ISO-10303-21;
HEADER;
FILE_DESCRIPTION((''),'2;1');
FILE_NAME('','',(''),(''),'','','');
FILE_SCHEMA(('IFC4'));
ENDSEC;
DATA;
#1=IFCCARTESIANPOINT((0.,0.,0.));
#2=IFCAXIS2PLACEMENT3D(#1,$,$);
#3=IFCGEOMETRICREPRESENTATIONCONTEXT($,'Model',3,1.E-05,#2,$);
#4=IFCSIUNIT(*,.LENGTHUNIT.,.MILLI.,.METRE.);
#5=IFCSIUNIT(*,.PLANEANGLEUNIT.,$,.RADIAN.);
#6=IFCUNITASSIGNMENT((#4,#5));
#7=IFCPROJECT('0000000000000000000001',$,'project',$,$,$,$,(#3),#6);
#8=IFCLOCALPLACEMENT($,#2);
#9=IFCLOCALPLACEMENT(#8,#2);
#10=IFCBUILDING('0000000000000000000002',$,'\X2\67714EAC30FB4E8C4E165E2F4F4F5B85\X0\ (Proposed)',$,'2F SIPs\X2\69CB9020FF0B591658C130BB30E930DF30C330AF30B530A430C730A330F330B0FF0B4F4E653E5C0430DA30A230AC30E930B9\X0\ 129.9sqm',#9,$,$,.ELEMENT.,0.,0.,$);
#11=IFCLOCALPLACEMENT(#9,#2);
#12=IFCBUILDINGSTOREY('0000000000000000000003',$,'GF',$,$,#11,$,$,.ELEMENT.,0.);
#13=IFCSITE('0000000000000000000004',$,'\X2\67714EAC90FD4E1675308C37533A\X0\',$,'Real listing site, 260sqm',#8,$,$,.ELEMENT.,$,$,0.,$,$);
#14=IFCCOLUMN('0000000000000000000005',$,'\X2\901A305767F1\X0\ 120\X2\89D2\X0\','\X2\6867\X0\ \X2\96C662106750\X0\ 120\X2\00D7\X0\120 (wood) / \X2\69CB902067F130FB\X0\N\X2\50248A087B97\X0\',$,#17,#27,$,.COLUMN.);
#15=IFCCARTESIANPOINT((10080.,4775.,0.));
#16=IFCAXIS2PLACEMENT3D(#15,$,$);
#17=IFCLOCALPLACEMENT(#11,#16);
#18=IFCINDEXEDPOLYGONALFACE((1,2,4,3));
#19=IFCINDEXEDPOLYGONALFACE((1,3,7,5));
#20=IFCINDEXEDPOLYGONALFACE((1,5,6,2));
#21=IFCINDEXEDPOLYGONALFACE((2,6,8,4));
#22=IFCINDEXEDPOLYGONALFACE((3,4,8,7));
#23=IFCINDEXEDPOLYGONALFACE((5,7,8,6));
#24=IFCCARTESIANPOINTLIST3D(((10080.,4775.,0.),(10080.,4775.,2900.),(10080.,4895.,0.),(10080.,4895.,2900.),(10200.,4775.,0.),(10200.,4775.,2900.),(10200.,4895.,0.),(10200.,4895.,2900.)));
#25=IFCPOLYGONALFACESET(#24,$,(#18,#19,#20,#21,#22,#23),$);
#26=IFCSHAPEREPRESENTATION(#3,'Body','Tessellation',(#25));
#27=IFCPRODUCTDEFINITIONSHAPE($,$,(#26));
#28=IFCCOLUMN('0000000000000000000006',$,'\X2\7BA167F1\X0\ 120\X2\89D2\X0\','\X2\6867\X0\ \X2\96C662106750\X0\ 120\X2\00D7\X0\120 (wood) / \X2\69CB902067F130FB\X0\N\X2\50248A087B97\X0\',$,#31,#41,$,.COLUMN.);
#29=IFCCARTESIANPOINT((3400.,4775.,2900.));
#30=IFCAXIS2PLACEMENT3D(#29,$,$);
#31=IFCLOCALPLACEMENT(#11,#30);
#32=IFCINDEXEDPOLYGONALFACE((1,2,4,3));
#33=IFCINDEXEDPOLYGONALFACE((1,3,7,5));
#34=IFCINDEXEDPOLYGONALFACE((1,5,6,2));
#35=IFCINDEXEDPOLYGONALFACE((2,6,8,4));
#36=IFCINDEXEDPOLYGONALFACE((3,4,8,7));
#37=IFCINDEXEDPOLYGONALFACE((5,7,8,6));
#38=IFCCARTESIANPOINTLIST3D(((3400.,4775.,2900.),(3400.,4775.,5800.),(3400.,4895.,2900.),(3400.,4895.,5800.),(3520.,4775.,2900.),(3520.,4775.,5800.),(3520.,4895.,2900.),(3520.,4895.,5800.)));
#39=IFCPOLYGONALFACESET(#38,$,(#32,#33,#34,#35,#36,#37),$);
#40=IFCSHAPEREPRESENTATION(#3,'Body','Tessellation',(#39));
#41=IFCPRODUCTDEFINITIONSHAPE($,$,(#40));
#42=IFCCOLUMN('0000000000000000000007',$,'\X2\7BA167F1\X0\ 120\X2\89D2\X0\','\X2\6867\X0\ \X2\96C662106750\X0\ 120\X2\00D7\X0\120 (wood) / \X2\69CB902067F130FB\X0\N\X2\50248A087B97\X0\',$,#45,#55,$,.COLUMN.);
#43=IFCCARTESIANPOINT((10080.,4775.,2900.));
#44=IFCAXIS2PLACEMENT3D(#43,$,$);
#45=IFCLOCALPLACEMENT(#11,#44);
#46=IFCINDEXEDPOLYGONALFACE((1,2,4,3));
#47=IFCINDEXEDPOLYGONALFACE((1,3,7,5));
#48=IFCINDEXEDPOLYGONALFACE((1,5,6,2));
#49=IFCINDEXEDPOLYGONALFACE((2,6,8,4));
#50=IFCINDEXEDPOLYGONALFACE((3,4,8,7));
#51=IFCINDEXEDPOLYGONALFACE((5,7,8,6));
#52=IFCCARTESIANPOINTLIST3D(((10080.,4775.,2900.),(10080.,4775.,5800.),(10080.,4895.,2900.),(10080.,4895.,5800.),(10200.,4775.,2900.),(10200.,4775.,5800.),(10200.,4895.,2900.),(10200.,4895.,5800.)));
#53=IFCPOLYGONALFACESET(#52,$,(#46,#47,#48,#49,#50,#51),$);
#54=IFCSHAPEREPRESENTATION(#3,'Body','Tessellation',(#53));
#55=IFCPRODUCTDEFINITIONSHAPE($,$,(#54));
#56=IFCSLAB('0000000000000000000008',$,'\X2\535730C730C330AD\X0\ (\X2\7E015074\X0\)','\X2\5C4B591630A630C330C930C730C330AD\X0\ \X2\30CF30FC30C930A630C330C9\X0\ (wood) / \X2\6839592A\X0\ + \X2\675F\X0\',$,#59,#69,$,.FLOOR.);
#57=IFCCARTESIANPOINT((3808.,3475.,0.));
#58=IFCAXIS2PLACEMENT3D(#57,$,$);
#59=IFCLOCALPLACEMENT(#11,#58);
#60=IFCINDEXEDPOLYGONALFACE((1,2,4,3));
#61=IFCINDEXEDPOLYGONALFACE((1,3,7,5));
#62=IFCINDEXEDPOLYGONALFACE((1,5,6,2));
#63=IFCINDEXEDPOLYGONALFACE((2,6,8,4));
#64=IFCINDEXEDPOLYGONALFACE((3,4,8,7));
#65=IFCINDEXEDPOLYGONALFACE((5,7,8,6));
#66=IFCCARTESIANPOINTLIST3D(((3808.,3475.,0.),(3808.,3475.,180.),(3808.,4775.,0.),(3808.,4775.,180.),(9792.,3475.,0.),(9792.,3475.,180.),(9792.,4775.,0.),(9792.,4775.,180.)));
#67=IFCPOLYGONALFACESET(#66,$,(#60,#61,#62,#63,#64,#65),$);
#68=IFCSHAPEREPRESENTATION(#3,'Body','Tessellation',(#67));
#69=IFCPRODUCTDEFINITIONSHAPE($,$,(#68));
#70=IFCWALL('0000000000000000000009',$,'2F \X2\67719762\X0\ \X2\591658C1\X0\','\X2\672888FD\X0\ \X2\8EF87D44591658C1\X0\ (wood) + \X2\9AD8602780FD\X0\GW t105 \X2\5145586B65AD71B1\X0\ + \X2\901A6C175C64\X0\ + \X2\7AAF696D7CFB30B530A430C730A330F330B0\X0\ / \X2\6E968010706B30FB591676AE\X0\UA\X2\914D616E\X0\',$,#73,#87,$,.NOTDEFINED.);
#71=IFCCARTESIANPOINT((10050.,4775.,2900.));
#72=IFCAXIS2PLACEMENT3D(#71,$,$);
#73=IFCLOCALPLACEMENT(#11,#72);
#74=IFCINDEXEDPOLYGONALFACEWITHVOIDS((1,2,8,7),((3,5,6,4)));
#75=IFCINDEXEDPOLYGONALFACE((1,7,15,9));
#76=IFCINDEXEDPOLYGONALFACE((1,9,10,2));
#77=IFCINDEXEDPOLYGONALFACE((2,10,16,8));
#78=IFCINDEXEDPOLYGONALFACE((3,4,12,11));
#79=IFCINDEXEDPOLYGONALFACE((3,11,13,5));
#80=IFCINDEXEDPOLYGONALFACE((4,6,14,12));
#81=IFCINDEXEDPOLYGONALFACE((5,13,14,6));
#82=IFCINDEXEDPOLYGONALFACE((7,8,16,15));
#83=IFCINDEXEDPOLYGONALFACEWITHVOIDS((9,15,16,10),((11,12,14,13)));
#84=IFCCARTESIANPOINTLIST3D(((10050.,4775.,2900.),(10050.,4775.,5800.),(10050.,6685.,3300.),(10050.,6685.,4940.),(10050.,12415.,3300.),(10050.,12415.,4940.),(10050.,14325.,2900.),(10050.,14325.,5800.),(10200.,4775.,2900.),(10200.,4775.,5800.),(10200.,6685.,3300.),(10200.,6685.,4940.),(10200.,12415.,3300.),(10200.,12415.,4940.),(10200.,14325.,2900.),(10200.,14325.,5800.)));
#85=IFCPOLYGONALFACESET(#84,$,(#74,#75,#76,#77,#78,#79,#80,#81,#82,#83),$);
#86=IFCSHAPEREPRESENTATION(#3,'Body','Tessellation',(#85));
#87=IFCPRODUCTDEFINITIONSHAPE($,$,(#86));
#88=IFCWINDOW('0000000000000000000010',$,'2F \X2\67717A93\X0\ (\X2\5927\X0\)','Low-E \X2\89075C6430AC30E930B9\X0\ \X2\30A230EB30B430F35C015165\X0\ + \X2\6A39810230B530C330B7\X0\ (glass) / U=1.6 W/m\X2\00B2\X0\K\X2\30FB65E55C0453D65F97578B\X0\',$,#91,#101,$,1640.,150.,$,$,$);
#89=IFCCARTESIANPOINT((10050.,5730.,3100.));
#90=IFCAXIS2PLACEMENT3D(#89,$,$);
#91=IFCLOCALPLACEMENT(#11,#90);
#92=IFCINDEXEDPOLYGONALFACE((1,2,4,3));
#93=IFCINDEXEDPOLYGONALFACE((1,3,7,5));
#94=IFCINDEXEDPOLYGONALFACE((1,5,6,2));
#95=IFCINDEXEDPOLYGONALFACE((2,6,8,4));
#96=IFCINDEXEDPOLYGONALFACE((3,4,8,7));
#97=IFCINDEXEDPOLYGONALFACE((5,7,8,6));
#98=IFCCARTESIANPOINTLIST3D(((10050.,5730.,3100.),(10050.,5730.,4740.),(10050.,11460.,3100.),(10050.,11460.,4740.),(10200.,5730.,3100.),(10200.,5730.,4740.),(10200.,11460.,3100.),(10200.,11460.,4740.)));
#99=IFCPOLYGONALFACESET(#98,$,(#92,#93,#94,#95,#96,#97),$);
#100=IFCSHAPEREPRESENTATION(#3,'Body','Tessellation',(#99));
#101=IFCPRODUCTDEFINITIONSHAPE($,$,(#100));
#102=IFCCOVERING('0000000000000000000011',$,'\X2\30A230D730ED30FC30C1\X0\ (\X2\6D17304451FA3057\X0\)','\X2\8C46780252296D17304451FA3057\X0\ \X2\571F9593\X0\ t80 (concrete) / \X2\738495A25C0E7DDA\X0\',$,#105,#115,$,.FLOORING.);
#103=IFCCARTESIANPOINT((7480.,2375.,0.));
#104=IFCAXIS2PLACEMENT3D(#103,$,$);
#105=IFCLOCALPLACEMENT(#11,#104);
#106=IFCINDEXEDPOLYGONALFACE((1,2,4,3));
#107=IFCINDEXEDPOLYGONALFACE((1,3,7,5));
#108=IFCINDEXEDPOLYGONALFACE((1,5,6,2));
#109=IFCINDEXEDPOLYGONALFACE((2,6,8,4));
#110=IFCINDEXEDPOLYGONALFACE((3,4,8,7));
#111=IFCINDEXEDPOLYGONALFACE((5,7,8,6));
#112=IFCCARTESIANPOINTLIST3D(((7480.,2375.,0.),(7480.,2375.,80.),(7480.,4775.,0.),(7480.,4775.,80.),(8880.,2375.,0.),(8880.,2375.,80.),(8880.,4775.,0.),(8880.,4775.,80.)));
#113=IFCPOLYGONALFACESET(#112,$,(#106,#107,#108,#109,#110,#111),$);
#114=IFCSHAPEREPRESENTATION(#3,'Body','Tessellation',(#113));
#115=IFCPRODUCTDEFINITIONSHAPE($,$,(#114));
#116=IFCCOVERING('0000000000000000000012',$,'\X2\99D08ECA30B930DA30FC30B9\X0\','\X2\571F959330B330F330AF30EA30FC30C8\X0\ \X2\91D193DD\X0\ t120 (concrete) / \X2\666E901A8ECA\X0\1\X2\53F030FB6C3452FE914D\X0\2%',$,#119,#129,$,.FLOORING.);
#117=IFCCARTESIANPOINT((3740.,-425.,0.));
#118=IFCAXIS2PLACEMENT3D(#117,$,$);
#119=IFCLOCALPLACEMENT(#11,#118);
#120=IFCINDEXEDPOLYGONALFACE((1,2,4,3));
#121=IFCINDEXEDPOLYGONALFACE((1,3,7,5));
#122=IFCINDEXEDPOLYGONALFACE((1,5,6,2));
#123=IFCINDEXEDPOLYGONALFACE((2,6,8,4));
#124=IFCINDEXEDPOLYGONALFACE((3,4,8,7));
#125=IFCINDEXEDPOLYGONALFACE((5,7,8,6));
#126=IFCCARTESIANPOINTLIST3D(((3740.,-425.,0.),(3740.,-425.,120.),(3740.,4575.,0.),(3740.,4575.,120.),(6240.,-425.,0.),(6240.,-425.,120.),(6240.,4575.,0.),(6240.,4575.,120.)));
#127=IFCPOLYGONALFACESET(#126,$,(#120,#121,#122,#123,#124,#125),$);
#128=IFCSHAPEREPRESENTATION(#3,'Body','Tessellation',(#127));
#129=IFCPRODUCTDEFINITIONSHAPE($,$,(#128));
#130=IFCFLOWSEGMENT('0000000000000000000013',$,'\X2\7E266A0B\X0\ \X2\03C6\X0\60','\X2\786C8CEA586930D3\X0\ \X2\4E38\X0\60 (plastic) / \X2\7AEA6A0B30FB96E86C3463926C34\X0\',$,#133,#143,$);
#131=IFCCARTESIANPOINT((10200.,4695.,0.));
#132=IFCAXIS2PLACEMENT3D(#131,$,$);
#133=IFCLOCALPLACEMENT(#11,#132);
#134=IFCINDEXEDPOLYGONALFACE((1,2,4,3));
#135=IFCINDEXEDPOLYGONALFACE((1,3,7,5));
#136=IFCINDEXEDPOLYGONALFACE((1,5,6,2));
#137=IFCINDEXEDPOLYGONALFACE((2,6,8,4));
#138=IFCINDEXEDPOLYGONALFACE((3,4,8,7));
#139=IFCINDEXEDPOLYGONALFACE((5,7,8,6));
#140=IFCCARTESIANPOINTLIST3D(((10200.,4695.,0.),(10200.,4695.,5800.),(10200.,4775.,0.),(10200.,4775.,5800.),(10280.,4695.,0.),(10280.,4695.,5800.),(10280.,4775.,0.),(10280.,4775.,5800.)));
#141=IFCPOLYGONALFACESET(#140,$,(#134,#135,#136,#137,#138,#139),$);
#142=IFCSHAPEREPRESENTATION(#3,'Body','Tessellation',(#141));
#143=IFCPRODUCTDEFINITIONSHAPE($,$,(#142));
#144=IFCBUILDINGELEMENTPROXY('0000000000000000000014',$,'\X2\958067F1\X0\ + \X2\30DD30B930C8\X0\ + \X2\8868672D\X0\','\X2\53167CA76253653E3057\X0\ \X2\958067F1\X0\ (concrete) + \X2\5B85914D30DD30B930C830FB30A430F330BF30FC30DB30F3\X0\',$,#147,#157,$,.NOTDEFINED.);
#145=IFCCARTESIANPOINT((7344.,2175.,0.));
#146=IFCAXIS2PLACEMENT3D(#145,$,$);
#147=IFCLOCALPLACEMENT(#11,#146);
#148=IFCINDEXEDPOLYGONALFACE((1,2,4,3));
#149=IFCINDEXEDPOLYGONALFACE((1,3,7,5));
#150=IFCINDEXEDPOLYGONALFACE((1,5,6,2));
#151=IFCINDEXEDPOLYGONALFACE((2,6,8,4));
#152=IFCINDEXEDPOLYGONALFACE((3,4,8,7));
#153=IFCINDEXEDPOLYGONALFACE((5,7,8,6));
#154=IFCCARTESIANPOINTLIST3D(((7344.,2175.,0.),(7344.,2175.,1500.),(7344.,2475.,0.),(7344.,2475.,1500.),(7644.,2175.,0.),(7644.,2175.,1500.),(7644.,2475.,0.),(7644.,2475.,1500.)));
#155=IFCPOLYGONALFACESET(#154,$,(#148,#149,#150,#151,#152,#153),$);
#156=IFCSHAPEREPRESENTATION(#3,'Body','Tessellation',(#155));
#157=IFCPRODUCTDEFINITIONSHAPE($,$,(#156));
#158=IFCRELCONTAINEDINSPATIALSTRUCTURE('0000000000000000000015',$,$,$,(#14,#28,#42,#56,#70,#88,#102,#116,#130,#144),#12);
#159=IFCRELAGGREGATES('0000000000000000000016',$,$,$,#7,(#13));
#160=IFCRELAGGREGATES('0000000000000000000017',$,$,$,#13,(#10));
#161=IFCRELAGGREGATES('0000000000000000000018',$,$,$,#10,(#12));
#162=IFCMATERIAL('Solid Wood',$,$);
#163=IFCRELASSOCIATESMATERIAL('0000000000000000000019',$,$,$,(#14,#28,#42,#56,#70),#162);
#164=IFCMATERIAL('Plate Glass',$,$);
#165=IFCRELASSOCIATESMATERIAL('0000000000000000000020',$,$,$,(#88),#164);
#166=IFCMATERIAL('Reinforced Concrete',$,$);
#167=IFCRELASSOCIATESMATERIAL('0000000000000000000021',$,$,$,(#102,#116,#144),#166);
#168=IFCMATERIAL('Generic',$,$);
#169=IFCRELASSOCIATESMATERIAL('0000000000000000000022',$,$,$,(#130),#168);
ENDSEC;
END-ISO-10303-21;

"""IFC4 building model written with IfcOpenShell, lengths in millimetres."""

from ifc_helpers import new_model, si_unit, frame, frame_2d, origin, place, context, project, spatial, rectangle, extrude, material, element, fill, save


model = new_model("IFC4")

# Units and contexts
model_context = context("Model", 3, precision=1e-05, world=origin())
ifc_project = project(units=[si_unit("LENGTHUNIT", "METRE", prefix="MILLI"), si_unit("PLANEANGLEUNIT", "RADIAN")], contexts=[model_context])

# Site, building, storey
site_placement = place(None, origin())
site = spatial("IfcSite", under=ifc_project, at=site_placement, Name="東京都世田谷区", ObjectType="Real listing site, 260sqm", CompositionType="ELEMENT", RefElevation=0.0)
building_placement = place(site_placement, origin())
building = spatial("IfcBuilding", under=site, at=building_placement, Name="東京・二世帯住宅 (Proposed)", ObjectType="2F SIPs構造＋外壁セラミックサイディング＋低放射ペアガラス 129.9sqm", CompositionType="ELEMENT", ElevationOfRefHeight=0.0, ElevationOfTerrain=0.0)
storey_placement = place(building_placement, origin())
storey = spatial("IfcBuildingStorey", under=building, at=storey_placement, Name="GF", CompositionType="ELEMENT", Elevation=0.0)

# Columns
ifc_material_1 = material(Name="Solid Wood")
column_1_placement = place(storey_placement, frame((10080.0, 4775.0, 0.0)))
element("IfcColumn", 1, at=column_1_placement, inside=storey, material=ifc_material_1, Name="通し柱 120角", Description="桧 集成材 120×120 (wood) / 構造柱・N値計算", PredefinedType="COLUMN", context=model_context, shape_type="SweptSolid", body=[
    extrude(rectangle(XDim=120.0, YDim=120.0, at=frame_2d((60.0, 60.0))), frame((10080.0, 4775.0, 0.0)), (0.0, 0.0, 1.0), 2900.0),
])
column_2_placement = place(storey_placement, frame((3400.0, 4775.0, 2900.0)))
element("IfcColumn", 2, at=column_2_placement, inside=storey, material=ifc_material_1, Name="管柱 120角", Description="桧 集成材 120×120 (wood) / 構造柱・N値計算", PredefinedType="COLUMN", context=model_context, shape_type="SweptSolid", body=[
    extrude(rectangle(XDim=120.0, YDim=120.0, at=frame_2d((60.0, 60.0))), frame((3400.0, 4775.0, 2900.0)), (0.0, 0.0, 1.0), 2900.0),
])
column_3_placement = place(storey_placement, frame((10080.0, 4775.0, 2900.0)))
element("IfcColumn", 3, at=column_3_placement, inside=storey, material=ifc_material_1, Name="管柱 120角", Description="桧 集成材 120×120 (wood) / 構造柱・N値計算", PredefinedType="COLUMN", context=model_context, shape_type="SweptSolid", body=[
    extrude(rectangle(XDim=120.0, YDim=120.0, at=frame_2d((60.0, 60.0))), frame((10080.0, 4775.0, 2900.0)), (0.0, 0.0, 1.0), 2900.0),
])

# Slab
slab_placement = place(storey_placement, frame((3808.0, 3475.0, 0.0)))
element("IfcSlab", 4, at=slab_placement, inside=storey, material=ifc_material_1, Name="南デッキ (縁側)", Description="屋外ウッドデッキ ハードウッド (wood) / 根太 + 束", PredefinedType="FLOOR", context=model_context, shape_type="SweptSolid", body=[
    extrude(rectangle(XDim=5984.0, YDim=1300.0, at=frame_2d((2992.0, 650.0))), frame((3808.0, 3475.0, 0.0)), (0.0, 0.0, 1.0), 180.0),
])

# Wall, opening, window
ifc_material_2 = material(Name="Plate Glass")
wall_1_placement = place(storey_placement, frame((10050.0, 4775.0, 2900.0)))
wall_1 = element("IfcWall", 5, at=wall_1_placement, inside=storey, material=ifc_material_1, Name="2F 東面 外壁", Description="木製 軸組外壁 (wood) + 高性能GW t105 充填断熱 + 通気層 + 窯業系サイディング / 準耐火・外皮UA配慮", PredefinedType="NOTDEFINED", context=model_context, shape_type="SweptSolid", body=[
    extrude(rectangle(XDim=150.0, YDim=9550.0, at=frame_2d((75.0, 4775.0))), frame((10050.0, 4775.0, 2900.0)), (0.0, 0.0, 1.0), 2900.0),
])
opening_1_placement = place(storey_placement, frame((10050.0, 5730.0, 3100.0)))
opening_1 = element("IfcOpeningElement", 6, at=opening_1_placement, cuts=wall_1, PredefinedType="NOTDEFINED", context=model_context, shape_type="SweptSolid", body=[
    extrude(rectangle(XDim=150.0, YDim=5730.0, at=frame_2d((75.0, 2865.0))), frame((10050.0, 5730.0, 3100.0)), (0.0, 0.0, 1.0), 1640.0),
])
window_1_placement = place(storey_placement, frame((10050.0, 5730.0, 3100.0)))
window_1 = element("IfcWindow", 7, at=window_1_placement, inside=storey, material=ifc_material_2, Name="2F 東窓 (大)", Description="Low-E 複層ガラス アルゴン封入 + 樹脂サッシ (glass) / U=1.6 W/m²K・日射取得型", OverallHeight=1640.0, OverallWidth=150.0, context=model_context, shape_type="SweptSolid", body=[
    extrude(rectangle(XDim=150.0, YDim=5730.0, at=frame_2d((75.0, 2865.0))), frame((10050.0, 5730.0, 3100.0)), (0.0, 0.0, 1.0), 1640.0),
])
fill(opening_1, window_1)

# Coverings
ifc_material_3 = material(Name="Reinforced Concrete")
covering_1_placement = place(storey_placement, frame((7480.0, 2375.0, 0.0)))
element("IfcCovering", 8, at=covering_1_placement, inside=storey, material=ifc_material_3, Name="アプローチ (洗い出し)", Description="豆砂利洗い出し 土間 t80 (concrete) / 玄関導線", PredefinedType="FLOORING", context=model_context, shape_type="SweptSolid", body=[
    extrude(rectangle(XDim=1400.0, YDim=2400.0, at=frame_2d((700.0, 1200.0))), frame((7480.0, 2375.0, 0.0)), (0.0, 0.0, 1.0), 80.0),
])
covering_2_placement = place(storey_placement, frame((3740.0, -425.0, 0.0)))
element("IfcCovering", 9, at=covering_2_placement, inside=storey, material=ifc_material_3, Name="駐車スペース", Description="土間コンクリート 金鏝 t120 (concrete) / 普通車1台・水勾配2%", PredefinedType="FLOORING", context=model_context, shape_type="SweptSolid", body=[
    extrude(rectangle(XDim=2500.0, YDim=5000.0, at=frame_2d((1250.0, 2500.0))), frame((3740.0, -425.0, 0.0)), (0.0, 0.0, 1.0), 120.0),
])

# Flow segment
ifc_material_4 = material(Name="Generic")
flow_segment_placement = place(storey_placement, frame((10200.0, 4695.0, 0.0)))
element("IfcFlowSegment", 10, at=flow_segment_placement, inside=storey, material=ifc_material_4, Name="縦樋 φ60", Description="硬質塩ビ 丸60 (plastic) / 竪樋・雨水排水", context=model_context, shape_type="SweptSolid", body=[
    extrude(rectangle(XDim=80.0, YDim=80.0, at=frame_2d((40.0, 40.0))), frame((10200.0, 4695.0, 0.0)), (0.0, 0.0, 1.0), 5800.0),
])

# Building element proxy
proxy_placement = place(storey_placement, frame((7344.0, 2175.0, 0.0)))
element("IfcBuildingElementProxy", 11, at=proxy_placement, inside=storey, material=ifc_material_3, Name="門柱 + ポスト + 表札", Description="化粧打放し 門柱 (concrete) + 宅配ポスト・インターホン", PredefinedType="NOTDEFINED", context=model_context, shape_type="SweptSolid", body=[
    extrude(rectangle(XDim=300.0, YDim=300.0, at=frame_2d((150.0, 150.0))), frame((7344.0, 2175.0, 0.0)), (0.0, 0.0, 1.0), 1500.0),
])

save(model, "model.ifc")
